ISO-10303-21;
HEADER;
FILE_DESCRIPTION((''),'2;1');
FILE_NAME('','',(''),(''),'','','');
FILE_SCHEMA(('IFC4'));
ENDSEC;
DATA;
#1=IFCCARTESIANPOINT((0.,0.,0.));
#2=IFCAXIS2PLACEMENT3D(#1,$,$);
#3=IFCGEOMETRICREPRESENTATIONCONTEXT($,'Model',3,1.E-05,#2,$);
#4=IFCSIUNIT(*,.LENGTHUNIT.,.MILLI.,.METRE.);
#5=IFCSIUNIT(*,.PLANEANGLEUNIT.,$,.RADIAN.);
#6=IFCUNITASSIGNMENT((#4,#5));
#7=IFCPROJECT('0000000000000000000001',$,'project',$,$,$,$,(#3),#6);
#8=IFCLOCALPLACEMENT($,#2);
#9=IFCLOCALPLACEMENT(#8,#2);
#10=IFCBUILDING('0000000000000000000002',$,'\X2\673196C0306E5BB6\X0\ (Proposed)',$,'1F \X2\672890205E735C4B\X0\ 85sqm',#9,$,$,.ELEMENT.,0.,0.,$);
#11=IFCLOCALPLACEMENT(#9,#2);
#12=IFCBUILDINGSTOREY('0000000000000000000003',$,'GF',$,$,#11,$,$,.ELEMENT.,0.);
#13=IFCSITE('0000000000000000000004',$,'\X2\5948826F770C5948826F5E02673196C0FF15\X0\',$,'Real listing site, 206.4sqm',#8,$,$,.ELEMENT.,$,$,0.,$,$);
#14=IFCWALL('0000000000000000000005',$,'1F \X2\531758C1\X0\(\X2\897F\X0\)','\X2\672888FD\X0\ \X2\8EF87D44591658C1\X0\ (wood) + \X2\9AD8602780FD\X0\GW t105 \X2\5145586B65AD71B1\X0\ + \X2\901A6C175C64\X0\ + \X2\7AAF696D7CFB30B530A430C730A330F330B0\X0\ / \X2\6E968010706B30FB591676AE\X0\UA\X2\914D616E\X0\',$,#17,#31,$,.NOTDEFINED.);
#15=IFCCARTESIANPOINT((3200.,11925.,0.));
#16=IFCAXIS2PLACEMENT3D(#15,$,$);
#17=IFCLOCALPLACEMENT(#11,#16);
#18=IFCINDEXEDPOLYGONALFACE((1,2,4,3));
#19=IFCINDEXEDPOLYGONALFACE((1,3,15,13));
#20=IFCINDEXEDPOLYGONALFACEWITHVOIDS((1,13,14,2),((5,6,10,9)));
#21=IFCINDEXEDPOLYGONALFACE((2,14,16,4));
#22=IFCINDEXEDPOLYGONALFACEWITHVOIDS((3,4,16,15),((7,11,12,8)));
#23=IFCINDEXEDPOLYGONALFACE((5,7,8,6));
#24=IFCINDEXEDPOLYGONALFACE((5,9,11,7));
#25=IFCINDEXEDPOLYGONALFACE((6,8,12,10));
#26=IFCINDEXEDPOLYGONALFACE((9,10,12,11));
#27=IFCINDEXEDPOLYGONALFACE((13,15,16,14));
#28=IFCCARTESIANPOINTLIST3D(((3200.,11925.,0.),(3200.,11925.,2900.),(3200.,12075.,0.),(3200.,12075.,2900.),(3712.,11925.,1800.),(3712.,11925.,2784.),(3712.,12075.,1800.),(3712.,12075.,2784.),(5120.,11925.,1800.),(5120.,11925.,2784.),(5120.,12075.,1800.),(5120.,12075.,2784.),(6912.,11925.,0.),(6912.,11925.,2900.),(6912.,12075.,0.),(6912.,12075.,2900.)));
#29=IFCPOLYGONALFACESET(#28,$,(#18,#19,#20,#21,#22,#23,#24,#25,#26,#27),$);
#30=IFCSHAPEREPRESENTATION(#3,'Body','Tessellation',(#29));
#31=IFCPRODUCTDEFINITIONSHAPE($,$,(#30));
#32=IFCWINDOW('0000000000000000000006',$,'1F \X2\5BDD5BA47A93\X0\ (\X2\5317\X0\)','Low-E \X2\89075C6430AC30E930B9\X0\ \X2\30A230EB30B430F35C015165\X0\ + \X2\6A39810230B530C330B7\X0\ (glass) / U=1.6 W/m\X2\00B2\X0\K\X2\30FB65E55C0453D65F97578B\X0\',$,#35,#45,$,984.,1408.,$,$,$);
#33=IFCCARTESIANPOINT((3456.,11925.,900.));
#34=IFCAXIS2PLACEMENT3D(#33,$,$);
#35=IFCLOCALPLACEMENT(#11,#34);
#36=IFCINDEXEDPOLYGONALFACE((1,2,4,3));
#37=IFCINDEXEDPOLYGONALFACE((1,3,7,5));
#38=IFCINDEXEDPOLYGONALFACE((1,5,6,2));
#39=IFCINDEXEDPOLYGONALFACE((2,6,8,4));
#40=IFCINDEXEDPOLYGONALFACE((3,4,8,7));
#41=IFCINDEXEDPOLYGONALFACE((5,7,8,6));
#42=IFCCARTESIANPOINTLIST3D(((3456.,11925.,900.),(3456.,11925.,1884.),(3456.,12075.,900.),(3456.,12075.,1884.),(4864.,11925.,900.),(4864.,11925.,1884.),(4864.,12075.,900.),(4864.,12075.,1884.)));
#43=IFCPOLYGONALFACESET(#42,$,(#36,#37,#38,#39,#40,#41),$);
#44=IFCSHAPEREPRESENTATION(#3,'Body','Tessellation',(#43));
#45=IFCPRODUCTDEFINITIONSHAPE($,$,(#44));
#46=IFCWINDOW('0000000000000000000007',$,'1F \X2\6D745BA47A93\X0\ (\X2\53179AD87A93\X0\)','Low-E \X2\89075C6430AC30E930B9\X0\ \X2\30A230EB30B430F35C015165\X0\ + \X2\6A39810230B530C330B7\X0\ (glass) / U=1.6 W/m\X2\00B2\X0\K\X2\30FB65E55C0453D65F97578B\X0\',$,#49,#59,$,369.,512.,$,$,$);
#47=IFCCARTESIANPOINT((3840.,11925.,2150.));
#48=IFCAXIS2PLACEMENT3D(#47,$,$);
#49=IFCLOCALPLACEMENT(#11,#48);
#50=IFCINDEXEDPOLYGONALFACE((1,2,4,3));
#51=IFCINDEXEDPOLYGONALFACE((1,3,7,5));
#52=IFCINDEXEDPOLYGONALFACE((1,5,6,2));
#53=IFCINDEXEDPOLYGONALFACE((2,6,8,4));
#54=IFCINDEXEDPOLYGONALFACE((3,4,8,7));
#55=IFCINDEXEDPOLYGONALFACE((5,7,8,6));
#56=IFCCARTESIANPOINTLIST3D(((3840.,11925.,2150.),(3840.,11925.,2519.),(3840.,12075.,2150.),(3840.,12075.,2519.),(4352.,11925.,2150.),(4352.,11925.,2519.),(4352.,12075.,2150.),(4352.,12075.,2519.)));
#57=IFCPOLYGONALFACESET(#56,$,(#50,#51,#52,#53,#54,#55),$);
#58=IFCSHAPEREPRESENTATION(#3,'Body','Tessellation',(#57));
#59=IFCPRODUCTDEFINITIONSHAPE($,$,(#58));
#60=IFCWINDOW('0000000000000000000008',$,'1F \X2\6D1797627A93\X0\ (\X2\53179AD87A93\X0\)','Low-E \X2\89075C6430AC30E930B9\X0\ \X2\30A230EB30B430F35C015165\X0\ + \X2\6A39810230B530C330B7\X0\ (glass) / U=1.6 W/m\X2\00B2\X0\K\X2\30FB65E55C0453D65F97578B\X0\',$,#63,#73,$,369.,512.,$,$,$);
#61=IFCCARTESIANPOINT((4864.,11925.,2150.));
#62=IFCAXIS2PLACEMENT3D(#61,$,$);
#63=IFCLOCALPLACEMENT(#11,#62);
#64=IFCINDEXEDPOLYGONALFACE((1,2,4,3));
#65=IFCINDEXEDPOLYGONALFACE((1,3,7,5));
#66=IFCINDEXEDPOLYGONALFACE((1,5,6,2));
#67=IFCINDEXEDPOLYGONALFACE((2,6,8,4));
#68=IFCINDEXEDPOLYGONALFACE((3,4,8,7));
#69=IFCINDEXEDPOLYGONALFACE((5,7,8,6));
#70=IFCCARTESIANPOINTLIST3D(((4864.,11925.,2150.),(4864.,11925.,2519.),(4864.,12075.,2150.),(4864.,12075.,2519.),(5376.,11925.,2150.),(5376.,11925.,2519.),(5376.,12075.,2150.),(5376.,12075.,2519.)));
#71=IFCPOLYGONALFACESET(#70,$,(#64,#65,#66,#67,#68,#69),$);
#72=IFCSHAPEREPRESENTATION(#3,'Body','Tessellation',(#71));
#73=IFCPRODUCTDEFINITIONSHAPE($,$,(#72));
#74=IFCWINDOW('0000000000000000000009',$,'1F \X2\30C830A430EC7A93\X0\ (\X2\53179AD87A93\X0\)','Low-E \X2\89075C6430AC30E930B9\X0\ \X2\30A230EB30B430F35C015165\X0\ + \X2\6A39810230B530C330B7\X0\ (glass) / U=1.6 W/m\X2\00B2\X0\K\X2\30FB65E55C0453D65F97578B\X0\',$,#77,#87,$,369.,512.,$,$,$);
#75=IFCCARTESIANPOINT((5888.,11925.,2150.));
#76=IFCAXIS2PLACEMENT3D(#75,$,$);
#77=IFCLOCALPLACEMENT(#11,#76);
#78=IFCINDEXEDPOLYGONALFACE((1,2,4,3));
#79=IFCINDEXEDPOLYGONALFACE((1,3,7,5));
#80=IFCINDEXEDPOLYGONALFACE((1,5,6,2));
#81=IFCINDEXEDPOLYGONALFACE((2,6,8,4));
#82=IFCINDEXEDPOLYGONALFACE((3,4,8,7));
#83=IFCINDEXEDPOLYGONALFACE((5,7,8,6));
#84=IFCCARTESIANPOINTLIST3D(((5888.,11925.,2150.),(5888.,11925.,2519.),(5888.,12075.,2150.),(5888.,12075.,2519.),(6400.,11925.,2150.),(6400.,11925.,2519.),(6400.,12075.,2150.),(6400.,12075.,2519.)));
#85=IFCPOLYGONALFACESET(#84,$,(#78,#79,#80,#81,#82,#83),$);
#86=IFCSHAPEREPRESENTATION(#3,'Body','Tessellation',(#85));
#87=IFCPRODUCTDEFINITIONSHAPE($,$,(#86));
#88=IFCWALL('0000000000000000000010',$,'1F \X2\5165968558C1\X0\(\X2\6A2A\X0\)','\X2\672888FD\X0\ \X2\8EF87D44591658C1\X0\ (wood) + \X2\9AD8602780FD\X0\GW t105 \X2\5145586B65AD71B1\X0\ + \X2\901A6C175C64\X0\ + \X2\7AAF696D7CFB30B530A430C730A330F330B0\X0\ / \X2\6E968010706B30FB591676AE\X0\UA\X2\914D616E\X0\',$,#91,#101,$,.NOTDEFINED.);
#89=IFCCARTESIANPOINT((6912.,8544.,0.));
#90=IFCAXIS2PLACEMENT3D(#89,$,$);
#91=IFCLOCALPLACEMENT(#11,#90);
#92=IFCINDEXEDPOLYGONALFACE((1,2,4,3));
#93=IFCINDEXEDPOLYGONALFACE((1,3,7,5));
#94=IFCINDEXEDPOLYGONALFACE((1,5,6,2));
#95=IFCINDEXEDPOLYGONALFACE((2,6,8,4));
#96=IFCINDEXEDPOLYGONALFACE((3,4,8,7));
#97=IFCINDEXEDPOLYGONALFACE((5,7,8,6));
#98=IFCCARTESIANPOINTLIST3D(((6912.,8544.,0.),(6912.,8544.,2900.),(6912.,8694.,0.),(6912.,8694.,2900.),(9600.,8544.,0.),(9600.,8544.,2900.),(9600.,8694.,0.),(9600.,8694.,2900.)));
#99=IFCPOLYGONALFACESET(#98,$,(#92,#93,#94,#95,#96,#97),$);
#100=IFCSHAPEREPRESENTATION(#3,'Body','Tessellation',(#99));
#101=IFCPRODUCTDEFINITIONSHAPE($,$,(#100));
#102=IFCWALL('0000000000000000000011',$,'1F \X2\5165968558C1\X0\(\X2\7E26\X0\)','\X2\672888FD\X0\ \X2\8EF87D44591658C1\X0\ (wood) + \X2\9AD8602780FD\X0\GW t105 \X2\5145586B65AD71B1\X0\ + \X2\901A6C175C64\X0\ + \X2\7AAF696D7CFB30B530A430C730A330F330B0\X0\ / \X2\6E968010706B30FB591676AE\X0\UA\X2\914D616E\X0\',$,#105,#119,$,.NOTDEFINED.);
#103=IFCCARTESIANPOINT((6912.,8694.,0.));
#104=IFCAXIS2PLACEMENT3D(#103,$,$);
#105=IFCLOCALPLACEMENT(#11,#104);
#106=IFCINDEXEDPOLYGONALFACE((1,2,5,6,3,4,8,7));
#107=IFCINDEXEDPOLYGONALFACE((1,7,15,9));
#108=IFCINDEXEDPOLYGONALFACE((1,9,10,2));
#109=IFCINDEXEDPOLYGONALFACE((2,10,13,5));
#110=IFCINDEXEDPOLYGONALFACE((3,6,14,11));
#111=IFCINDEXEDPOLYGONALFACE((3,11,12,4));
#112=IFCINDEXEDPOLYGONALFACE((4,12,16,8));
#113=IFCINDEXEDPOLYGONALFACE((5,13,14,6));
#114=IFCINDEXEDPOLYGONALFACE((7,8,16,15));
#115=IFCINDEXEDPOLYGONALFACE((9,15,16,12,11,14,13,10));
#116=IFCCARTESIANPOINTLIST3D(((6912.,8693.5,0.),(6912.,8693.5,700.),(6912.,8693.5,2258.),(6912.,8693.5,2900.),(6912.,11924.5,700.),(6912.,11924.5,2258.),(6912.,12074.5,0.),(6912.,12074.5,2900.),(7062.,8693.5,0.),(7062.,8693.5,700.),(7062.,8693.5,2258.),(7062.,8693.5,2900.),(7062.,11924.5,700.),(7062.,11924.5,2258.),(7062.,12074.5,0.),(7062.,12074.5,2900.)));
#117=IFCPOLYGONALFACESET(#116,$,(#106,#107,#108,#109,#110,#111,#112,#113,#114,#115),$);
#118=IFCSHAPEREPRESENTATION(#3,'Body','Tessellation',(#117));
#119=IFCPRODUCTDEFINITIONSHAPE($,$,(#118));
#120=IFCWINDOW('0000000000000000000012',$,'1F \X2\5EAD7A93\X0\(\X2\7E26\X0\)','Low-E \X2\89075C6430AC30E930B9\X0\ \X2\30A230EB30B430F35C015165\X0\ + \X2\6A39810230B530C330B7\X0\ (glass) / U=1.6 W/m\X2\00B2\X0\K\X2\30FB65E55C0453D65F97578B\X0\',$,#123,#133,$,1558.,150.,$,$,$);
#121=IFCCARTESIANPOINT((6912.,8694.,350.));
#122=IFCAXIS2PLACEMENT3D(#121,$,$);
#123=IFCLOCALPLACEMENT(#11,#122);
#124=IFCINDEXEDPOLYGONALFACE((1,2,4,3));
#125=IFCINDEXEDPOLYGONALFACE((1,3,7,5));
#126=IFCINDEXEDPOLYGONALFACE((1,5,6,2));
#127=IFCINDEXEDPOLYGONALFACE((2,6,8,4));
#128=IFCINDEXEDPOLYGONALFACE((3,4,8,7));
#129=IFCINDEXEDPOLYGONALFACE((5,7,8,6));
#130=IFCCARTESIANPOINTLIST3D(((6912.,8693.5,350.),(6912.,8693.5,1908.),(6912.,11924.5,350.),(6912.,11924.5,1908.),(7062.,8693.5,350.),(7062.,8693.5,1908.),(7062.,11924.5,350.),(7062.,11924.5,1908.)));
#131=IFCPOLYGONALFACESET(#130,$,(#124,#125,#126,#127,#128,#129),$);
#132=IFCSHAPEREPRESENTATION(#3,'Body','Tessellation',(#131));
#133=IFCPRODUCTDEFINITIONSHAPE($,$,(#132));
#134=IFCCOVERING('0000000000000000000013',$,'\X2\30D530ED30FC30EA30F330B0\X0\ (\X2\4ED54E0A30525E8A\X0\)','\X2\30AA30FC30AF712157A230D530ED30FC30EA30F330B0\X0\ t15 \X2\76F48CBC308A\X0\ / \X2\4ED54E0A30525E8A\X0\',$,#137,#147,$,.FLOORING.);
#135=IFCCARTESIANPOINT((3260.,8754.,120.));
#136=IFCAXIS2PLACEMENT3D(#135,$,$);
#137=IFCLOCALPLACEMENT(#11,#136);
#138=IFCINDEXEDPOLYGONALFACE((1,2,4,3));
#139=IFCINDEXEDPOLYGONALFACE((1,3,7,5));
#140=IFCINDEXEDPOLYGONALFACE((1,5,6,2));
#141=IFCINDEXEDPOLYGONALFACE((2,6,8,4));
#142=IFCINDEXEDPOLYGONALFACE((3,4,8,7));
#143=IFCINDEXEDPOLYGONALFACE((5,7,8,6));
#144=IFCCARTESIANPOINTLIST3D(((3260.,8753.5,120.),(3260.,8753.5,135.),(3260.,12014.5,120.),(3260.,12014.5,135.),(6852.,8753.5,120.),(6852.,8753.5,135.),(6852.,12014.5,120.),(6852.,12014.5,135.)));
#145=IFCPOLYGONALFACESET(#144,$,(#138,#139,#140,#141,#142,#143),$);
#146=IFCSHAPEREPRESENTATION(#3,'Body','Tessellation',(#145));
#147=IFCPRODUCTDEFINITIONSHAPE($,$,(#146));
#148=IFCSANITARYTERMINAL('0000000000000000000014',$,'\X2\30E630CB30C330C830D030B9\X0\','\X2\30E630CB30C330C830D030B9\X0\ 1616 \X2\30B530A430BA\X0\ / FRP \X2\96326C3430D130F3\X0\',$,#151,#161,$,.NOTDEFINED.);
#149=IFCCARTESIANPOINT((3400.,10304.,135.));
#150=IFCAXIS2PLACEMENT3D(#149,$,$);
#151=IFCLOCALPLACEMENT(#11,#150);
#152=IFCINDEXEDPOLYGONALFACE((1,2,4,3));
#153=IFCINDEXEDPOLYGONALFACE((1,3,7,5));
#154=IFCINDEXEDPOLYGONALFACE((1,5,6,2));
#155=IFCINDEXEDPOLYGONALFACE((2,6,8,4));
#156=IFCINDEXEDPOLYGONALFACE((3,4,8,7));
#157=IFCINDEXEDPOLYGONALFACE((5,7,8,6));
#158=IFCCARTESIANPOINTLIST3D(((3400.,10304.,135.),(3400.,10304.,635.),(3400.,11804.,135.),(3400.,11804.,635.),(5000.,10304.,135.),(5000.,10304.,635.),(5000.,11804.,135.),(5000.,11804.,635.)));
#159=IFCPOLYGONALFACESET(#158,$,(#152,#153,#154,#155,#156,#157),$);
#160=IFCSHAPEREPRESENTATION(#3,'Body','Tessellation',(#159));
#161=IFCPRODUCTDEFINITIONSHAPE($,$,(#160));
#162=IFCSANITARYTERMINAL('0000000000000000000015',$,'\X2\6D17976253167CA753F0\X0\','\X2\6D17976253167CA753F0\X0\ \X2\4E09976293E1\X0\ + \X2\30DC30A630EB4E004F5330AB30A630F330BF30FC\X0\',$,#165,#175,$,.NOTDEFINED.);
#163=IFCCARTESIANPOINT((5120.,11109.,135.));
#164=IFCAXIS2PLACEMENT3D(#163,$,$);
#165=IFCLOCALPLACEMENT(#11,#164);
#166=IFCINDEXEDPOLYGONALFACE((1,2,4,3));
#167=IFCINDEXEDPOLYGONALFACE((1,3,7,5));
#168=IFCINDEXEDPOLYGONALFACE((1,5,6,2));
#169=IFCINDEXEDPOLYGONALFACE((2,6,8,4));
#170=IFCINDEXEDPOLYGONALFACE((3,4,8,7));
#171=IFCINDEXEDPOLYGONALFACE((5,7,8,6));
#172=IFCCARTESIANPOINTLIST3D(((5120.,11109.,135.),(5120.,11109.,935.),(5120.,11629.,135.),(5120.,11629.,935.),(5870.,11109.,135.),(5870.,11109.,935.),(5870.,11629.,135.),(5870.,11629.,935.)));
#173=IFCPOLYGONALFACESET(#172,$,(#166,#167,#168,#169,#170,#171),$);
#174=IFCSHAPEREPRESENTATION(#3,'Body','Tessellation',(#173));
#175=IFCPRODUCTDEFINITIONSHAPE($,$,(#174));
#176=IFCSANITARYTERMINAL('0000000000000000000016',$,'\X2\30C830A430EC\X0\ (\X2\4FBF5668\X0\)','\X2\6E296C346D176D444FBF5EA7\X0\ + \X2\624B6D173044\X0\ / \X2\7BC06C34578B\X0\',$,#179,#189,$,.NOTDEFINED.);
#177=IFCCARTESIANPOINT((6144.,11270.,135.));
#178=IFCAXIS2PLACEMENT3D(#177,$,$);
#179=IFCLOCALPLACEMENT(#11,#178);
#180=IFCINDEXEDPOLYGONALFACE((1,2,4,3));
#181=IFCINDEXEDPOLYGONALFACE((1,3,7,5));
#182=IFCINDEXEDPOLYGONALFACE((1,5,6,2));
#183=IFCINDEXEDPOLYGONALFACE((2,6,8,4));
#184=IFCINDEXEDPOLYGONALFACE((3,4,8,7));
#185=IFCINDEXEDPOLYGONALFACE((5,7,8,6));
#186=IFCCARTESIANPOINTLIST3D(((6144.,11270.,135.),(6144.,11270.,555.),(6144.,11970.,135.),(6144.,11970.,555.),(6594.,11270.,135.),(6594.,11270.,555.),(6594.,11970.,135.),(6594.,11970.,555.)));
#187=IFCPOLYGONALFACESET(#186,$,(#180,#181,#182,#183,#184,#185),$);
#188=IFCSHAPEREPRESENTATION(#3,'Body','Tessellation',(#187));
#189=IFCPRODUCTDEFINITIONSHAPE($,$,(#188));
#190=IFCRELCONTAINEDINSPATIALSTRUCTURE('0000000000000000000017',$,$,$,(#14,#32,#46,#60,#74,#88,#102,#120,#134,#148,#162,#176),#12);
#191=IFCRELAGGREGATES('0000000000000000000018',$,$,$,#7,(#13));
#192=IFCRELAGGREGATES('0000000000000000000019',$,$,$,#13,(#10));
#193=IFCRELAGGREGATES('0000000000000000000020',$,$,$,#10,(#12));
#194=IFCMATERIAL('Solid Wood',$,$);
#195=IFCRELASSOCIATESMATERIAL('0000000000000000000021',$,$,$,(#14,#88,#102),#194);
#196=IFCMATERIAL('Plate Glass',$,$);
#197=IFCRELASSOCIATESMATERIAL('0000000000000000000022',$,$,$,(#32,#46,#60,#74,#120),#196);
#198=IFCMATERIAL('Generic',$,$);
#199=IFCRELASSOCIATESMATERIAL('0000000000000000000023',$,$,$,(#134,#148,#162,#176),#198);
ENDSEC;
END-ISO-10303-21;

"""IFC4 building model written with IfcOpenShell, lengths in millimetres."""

from ifc_helpers import new_model, si_unit, frame, frame_2d, origin, place, context, project, spatial, rectangle, extrude, material, element, fill, save


model = new_model("IFC4")

# Units and contexts
model_context = context("Model", 3, precision=1e-05, world=origin())
ifc_project = project(units=[si_unit("LENGTHUNIT", "METRE", prefix="MILLI"), si_unit("PLANEANGLEUNIT", "RADIAN")], contexts=[model_context])

# Site, building, storey
site_placement = place(None, origin())
site = spatial("IfcSite", under=ifc_project, at=site_placement, Name="奈良県奈良市朱雀５", ObjectType="Real listing site, 206.4sqm", CompositionType="ELEMENT", RefElevation=0.0)
building_placement = place(site_placement, origin())
building = spatial("IfcBuilding", under=site, at=building_placement, Name="朱雀の家 (Proposed)", ObjectType="1F 木造平屋 85sqm", CompositionType="ELEMENT", ElevationOfRefHeight=0.0, ElevationOfTerrain=0.0)
storey_placement = place(building_placement, origin())
storey = spatial("IfcBuildingStorey", under=building, at=storey_placement, Name="GF", CompositionType="ELEMENT", Elevation=0.0)

# Shared definitions
ifc_material_1 = material(Name="Solid Wood")

# Wall, openings, windows
wall_1_placement = place(storey_placement, frame((3200.0, 11925.0, 0.0)))
wall_1 = element("IfcWall", 1, at=wall_1_placement, inside=storey, material=ifc_material_1, Name="1F 北壁(西)", Description="木製 軸組外壁 (wood) + 高性能GW t105 充填断熱 + 通気層 + 窯業系サイディング / 準耐火・外皮UA配慮", PredefinedType="NOTDEFINED", context=model_context, shape_type="SweptSolid", body=[
    extrude(rectangle(XDim=3712.0, YDim=150.0, at=frame_2d((1856.0, 75.0))), frame((3200.0, 11925.0, 0.0)), (0.0, 0.0, 1.0), 2900.0),
])
opening_1_placement = place(storey_placement, frame((3456.0, 11925.0, 900.0)))
opening_1 = element("IfcOpeningElement", 2, at=opening_1_placement, cuts=wall_1, PredefinedType="NOTDEFINED", context=model_context, shape_type="SweptSolid", body=[
    extrude(rectangle(XDim=1408.0, YDim=150.0, at=frame_2d((704.0, 75.0))), frame((3456.0, 11925.0, 900.0)), (0.0, 0.0, 1.0), 984.0),
])
opening_2_placement = place(storey_placement, frame((3840.0, 11925.0, 2150.0)))
opening_2 = element("IfcOpeningElement", 3, at=opening_2_placement, cuts=wall_1, PredefinedType="NOTDEFINED", context=model_context, shape_type="SweptSolid", body=[
    extrude(rectangle(XDim=512.0, YDim=150.0, at=frame_2d((256.0, 75.0))), frame((3840.0, 11925.0, 2150.0)), (0.0, 0.0, 1.0), 369.0),
])
opening_3_placement = place(storey_placement, frame((4864.0, 11925.0, 2150.0)))
opening_3 = element("IfcOpeningElement", 4, at=opening_3_placement, cuts=wall_1, PredefinedType="NOTDEFINED", context=model_context, shape_type="SweptSolid", body=[
    extrude(rectangle(XDim=512.0, YDim=150.0, at=frame_2d((256.0, 75.0))), frame((4864.0, 11925.0, 2150.0)), (0.0, 0.0, 1.0), 369.0),
])
opening_4_placement = place(storey_placement, frame((5888.0, 11925.0, 2150.0)))
opening_4 = element("IfcOpeningElement", 5, at=opening_4_placement, cuts=wall_1, PredefinedType="NOTDEFINED", context=model_context, shape_type="SweptSolid", body=[
    extrude(rectangle(XDim=512.0, YDim=150.0, at=frame_2d((256.0, 75.0))), frame((5888.0, 11925.0, 2150.0)), (0.0, 0.0, 1.0), 369.0),
])
ifc_material_2 = material(Name="Plate Glass")
window_1_placement = place(storey_placement, frame((3456.0, 11925.0, 900.0)))
window_1 = element("IfcWindow", 6, at=window_1_placement, inside=storey, material=ifc_material_2, Name="1F 寝室窓 (北)", Description="Low-E 複層ガラス アルゴン封入 + 樹脂サッシ (glass) / U=1.6 W/m²K・日射取得型", OverallHeight=984.0, OverallWidth=1408.0, context=model_context, shape_type="SweptSolid", body=[
    extrude(rectangle(XDim=1408.0, YDim=150.0, at=frame_2d((704.0, 75.0))), frame((3456.0, 11925.0, 900.0)), (0.0, 0.0, 1.0), 984.0),
])
fill(opening_1, window_1)
window_2_placement = place(storey_placement, frame((3840.0, 11925.0, 2150.0)))
window_2 = element("IfcWindow", 7, at=window_2_placement, inside=storey, material=ifc_material_2, Name="1F 浴室窓 (北高窓)", Description="Low-E 複層ガラス アルゴン封入 + 樹脂サッシ (glass) / U=1.6 W/m²K・日射取得型", OverallHeight=369.0, OverallWidth=512.0, context=model_context, shape_type="SweptSolid", body=[
    extrude(rectangle(XDim=512.0, YDim=150.0, at=frame_2d((256.0, 75.0))), frame((3840.0, 11925.0, 2150.0)), (0.0, 0.0, 1.0), 369.0),
])
fill(opening_2, window_2)
window_3_placement = place(storey_placement, frame((4864.0, 11925.0, 2150.0)))
window_3 = element("IfcWindow", 8, at=window_3_placement, inside=storey, material=ifc_material_2, Name="1F 洗面窓 (北高窓)", Description="Low-E 複層ガラス アルゴン封入 + 樹脂サッシ (glass) / U=1.6 W/m²K・日射取得型", OverallHeight=369.0, OverallWidth=512.0, context=model_context, shape_type="SweptSolid", body=[
    extrude(rectangle(XDim=512.0, YDim=150.0, at=frame_2d((256.0, 75.0))), frame((4864.0, 11925.0, 2150.0)), (0.0, 0.0, 1.0), 369.0),
])
fill(opening_3, window_3)
window_4_placement = place(storey_placement, frame((5888.0, 11925.0, 2150.0)))
window_4 = element("IfcWindow", 9, at=window_4_placement, inside=storey, material=ifc_material_2, Name="1F トイレ窓 (北高窓)", Description="Low-E 複層ガラス アルゴン封入 + 樹脂サッシ (glass) / U=1.6 W/m²K・日射取得型", OverallHeight=369.0, OverallWidth=512.0, context=model_context, shape_type="SweptSolid", body=[
    extrude(rectangle(XDim=512.0, YDim=150.0, at=frame_2d((256.0, 75.0))), frame((5888.0, 11925.0, 2150.0)), (0.0, 0.0, 1.0), 369.0),
])
fill(opening_4, window_4)

# Wall
wall_2_placement = place(storey_placement, frame((6912.0, 8544.0, 0.0)))
element("IfcWall", 10, at=wall_2_placement, inside=storey, material=ifc_material_1, Name="1F 入隅壁(横)", Description="木製 軸組外壁 (wood) + 高性能GW t105 充填断熱 + 通気層 + 窯業系サイディング / 準耐火・外皮UA配慮", PredefinedType="NOTDEFINED", context=model_context, shape_type="SweptSolid", body=[
    extrude(rectangle(XDim=2688.0, YDim=150.0, at=frame_2d((1344.0, 75.0))), frame((6912.0, 8544.0, 0.0)), (0.0, 0.0, 1.0), 2900.0),
])

# Wall, opening, window
wall_3_placement = place(storey_placement, frame((6912.0, 8694.0, 0.0)))
wall_3 = element("IfcWall", 11, at=wall_3_placement, inside=storey, material=ifc_material_1, Name="1F 入隅壁(縦)", Description="木製 軸組外壁 (wood) + 高性能GW t105 充填断熱 + 通気層 + 窯業系サイディング / 準耐火・外皮UA配慮", PredefinedType="NOTDEFINED", context=model_context, shape_type="SweptSolid", body=[
    extrude(rectangle(XDim=150.0, YDim=3381.0, at=frame_2d((75.0, 1690.0))), frame((6912.0, 8694.0, 0.0)), (0.0, 0.0, 1.0), 2900.0),
])
opening_5_placement = place(storey_placement, frame((6912.0, 8694.0, 350.0)))
opening_5 = element("IfcOpeningElement", 12, at=opening_5_placement, cuts=wall_3, PredefinedType="NOTDEFINED", context=model_context, shape_type="SweptSolid", body=[
    extrude(rectangle(XDim=150.0, YDim=3231.0, at=frame_2d((75.0, 1615.0))), frame((6912.0, 8694.0, 350.0)), (0.0, 0.0, 1.0), 1558.0),
])
window_5_placement = place(storey_placement, frame((6912.0, 8694.0, 350.0)))
window_5 = element("IfcWindow", 13, at=window_5_placement, inside=storey, material=ifc_material_2, Name="1F 庭窓(縦)", Description="Low-E 複層ガラス アルゴン封入 + 樹脂サッシ (glass) / U=1.6 W/m²K・日射取得型", OverallHeight=1558.0, OverallWidth=150.0, context=model_context, shape_type="SweptSolid", body=[
    extrude(rectangle(XDim=150.0, YDim=3231.0, at=frame_2d((75.0, 1615.0))), frame((6912.0, 8694.0, 350.0)), (0.0, 0.0, 1.0), 1558.0),
])
fill(opening_5, window_5)

# Covering
ifc_material_3 = material(Name="Generic")
covering_placement = place(storey_placement, frame((3260.0, 8754.0, 120.0)))
element("IfcCovering", 14, at=covering_placement, inside=storey, material=ifc_material_3, Name="フローリング (仕上げ床)", Description="オーク無垢フローリング t15 直貼り / 仕上げ床", PredefinedType="FLOORING", context=model_context, shape_type="SweptSolid", body=[
    extrude(rectangle(XDim=3592.0, YDim=3261.0, at=frame_2d((1796.0, 1630.0))), frame((3260.0, 8754.0, 120.0)), (0.0, 0.0, 1.0), 15.0),
])

# Sanitary terminals
sanitary_terminal_1_placement = place(storey_placement, frame((3400.0, 10304.0, 135.0)))
element("IfcSanitaryTerminal", 15, at=sanitary_terminal_1_placement, inside=storey, material=ifc_material_3, Name="ユニットバス", Description="ユニットバス 1616 サイズ / FRP 防水パン", PredefinedType="NOTDEFINED", context=model_context, shape_type="SweptSolid", body=[
    extrude(rectangle(XDim=1600.0, YDim=1500.0, at=frame_2d((800.0, 750.0))), frame((3400.0, 10304.0, 135.0)), (0.0, 0.0, 1.0), 500.0),
])
sanitary_terminal_2_placement = place(storey_placement, frame((5120.0, 11109.0, 135.0)))
element("IfcSanitaryTerminal", 16, at=sanitary_terminal_2_placement, inside=storey, material=ifc_material_3, Name="洗面化粧台", Description="洗面化粧台 三面鏡 + ボウル一体カウンター", PredefinedType="NOTDEFINED", context=model_context, shape_type="SweptSolid", body=[
    extrude(rectangle(XDim=750.0, YDim=520.0, at=frame_2d((375.0, 260.0))), frame((5120.0, 11109.0, 135.0)), (0.0, 0.0, 1.0), 800.0),
])
sanitary_terminal_3_placement = place(storey_placement, frame((6144.0, 11270.0, 135.0)))
element("IfcSanitaryTerminal", 17, at=sanitary_terminal_3_placement, inside=storey, material=ifc_material_3, Name="トイレ (便器)", Description="温水洗浄便座 + 手洗い / 節水型", PredefinedType="NOTDEFINED", context=model_context, shape_type="SweptSolid", body=[
    extrude(rectangle(XDim=450.0, YDim=700.0, at=frame_2d((225.0, 350.0))), frame((6144.0, 11270.0, 135.0)), (0.0, 0.0, 1.0), 420.0),
])

save(model, "model.ifc")
